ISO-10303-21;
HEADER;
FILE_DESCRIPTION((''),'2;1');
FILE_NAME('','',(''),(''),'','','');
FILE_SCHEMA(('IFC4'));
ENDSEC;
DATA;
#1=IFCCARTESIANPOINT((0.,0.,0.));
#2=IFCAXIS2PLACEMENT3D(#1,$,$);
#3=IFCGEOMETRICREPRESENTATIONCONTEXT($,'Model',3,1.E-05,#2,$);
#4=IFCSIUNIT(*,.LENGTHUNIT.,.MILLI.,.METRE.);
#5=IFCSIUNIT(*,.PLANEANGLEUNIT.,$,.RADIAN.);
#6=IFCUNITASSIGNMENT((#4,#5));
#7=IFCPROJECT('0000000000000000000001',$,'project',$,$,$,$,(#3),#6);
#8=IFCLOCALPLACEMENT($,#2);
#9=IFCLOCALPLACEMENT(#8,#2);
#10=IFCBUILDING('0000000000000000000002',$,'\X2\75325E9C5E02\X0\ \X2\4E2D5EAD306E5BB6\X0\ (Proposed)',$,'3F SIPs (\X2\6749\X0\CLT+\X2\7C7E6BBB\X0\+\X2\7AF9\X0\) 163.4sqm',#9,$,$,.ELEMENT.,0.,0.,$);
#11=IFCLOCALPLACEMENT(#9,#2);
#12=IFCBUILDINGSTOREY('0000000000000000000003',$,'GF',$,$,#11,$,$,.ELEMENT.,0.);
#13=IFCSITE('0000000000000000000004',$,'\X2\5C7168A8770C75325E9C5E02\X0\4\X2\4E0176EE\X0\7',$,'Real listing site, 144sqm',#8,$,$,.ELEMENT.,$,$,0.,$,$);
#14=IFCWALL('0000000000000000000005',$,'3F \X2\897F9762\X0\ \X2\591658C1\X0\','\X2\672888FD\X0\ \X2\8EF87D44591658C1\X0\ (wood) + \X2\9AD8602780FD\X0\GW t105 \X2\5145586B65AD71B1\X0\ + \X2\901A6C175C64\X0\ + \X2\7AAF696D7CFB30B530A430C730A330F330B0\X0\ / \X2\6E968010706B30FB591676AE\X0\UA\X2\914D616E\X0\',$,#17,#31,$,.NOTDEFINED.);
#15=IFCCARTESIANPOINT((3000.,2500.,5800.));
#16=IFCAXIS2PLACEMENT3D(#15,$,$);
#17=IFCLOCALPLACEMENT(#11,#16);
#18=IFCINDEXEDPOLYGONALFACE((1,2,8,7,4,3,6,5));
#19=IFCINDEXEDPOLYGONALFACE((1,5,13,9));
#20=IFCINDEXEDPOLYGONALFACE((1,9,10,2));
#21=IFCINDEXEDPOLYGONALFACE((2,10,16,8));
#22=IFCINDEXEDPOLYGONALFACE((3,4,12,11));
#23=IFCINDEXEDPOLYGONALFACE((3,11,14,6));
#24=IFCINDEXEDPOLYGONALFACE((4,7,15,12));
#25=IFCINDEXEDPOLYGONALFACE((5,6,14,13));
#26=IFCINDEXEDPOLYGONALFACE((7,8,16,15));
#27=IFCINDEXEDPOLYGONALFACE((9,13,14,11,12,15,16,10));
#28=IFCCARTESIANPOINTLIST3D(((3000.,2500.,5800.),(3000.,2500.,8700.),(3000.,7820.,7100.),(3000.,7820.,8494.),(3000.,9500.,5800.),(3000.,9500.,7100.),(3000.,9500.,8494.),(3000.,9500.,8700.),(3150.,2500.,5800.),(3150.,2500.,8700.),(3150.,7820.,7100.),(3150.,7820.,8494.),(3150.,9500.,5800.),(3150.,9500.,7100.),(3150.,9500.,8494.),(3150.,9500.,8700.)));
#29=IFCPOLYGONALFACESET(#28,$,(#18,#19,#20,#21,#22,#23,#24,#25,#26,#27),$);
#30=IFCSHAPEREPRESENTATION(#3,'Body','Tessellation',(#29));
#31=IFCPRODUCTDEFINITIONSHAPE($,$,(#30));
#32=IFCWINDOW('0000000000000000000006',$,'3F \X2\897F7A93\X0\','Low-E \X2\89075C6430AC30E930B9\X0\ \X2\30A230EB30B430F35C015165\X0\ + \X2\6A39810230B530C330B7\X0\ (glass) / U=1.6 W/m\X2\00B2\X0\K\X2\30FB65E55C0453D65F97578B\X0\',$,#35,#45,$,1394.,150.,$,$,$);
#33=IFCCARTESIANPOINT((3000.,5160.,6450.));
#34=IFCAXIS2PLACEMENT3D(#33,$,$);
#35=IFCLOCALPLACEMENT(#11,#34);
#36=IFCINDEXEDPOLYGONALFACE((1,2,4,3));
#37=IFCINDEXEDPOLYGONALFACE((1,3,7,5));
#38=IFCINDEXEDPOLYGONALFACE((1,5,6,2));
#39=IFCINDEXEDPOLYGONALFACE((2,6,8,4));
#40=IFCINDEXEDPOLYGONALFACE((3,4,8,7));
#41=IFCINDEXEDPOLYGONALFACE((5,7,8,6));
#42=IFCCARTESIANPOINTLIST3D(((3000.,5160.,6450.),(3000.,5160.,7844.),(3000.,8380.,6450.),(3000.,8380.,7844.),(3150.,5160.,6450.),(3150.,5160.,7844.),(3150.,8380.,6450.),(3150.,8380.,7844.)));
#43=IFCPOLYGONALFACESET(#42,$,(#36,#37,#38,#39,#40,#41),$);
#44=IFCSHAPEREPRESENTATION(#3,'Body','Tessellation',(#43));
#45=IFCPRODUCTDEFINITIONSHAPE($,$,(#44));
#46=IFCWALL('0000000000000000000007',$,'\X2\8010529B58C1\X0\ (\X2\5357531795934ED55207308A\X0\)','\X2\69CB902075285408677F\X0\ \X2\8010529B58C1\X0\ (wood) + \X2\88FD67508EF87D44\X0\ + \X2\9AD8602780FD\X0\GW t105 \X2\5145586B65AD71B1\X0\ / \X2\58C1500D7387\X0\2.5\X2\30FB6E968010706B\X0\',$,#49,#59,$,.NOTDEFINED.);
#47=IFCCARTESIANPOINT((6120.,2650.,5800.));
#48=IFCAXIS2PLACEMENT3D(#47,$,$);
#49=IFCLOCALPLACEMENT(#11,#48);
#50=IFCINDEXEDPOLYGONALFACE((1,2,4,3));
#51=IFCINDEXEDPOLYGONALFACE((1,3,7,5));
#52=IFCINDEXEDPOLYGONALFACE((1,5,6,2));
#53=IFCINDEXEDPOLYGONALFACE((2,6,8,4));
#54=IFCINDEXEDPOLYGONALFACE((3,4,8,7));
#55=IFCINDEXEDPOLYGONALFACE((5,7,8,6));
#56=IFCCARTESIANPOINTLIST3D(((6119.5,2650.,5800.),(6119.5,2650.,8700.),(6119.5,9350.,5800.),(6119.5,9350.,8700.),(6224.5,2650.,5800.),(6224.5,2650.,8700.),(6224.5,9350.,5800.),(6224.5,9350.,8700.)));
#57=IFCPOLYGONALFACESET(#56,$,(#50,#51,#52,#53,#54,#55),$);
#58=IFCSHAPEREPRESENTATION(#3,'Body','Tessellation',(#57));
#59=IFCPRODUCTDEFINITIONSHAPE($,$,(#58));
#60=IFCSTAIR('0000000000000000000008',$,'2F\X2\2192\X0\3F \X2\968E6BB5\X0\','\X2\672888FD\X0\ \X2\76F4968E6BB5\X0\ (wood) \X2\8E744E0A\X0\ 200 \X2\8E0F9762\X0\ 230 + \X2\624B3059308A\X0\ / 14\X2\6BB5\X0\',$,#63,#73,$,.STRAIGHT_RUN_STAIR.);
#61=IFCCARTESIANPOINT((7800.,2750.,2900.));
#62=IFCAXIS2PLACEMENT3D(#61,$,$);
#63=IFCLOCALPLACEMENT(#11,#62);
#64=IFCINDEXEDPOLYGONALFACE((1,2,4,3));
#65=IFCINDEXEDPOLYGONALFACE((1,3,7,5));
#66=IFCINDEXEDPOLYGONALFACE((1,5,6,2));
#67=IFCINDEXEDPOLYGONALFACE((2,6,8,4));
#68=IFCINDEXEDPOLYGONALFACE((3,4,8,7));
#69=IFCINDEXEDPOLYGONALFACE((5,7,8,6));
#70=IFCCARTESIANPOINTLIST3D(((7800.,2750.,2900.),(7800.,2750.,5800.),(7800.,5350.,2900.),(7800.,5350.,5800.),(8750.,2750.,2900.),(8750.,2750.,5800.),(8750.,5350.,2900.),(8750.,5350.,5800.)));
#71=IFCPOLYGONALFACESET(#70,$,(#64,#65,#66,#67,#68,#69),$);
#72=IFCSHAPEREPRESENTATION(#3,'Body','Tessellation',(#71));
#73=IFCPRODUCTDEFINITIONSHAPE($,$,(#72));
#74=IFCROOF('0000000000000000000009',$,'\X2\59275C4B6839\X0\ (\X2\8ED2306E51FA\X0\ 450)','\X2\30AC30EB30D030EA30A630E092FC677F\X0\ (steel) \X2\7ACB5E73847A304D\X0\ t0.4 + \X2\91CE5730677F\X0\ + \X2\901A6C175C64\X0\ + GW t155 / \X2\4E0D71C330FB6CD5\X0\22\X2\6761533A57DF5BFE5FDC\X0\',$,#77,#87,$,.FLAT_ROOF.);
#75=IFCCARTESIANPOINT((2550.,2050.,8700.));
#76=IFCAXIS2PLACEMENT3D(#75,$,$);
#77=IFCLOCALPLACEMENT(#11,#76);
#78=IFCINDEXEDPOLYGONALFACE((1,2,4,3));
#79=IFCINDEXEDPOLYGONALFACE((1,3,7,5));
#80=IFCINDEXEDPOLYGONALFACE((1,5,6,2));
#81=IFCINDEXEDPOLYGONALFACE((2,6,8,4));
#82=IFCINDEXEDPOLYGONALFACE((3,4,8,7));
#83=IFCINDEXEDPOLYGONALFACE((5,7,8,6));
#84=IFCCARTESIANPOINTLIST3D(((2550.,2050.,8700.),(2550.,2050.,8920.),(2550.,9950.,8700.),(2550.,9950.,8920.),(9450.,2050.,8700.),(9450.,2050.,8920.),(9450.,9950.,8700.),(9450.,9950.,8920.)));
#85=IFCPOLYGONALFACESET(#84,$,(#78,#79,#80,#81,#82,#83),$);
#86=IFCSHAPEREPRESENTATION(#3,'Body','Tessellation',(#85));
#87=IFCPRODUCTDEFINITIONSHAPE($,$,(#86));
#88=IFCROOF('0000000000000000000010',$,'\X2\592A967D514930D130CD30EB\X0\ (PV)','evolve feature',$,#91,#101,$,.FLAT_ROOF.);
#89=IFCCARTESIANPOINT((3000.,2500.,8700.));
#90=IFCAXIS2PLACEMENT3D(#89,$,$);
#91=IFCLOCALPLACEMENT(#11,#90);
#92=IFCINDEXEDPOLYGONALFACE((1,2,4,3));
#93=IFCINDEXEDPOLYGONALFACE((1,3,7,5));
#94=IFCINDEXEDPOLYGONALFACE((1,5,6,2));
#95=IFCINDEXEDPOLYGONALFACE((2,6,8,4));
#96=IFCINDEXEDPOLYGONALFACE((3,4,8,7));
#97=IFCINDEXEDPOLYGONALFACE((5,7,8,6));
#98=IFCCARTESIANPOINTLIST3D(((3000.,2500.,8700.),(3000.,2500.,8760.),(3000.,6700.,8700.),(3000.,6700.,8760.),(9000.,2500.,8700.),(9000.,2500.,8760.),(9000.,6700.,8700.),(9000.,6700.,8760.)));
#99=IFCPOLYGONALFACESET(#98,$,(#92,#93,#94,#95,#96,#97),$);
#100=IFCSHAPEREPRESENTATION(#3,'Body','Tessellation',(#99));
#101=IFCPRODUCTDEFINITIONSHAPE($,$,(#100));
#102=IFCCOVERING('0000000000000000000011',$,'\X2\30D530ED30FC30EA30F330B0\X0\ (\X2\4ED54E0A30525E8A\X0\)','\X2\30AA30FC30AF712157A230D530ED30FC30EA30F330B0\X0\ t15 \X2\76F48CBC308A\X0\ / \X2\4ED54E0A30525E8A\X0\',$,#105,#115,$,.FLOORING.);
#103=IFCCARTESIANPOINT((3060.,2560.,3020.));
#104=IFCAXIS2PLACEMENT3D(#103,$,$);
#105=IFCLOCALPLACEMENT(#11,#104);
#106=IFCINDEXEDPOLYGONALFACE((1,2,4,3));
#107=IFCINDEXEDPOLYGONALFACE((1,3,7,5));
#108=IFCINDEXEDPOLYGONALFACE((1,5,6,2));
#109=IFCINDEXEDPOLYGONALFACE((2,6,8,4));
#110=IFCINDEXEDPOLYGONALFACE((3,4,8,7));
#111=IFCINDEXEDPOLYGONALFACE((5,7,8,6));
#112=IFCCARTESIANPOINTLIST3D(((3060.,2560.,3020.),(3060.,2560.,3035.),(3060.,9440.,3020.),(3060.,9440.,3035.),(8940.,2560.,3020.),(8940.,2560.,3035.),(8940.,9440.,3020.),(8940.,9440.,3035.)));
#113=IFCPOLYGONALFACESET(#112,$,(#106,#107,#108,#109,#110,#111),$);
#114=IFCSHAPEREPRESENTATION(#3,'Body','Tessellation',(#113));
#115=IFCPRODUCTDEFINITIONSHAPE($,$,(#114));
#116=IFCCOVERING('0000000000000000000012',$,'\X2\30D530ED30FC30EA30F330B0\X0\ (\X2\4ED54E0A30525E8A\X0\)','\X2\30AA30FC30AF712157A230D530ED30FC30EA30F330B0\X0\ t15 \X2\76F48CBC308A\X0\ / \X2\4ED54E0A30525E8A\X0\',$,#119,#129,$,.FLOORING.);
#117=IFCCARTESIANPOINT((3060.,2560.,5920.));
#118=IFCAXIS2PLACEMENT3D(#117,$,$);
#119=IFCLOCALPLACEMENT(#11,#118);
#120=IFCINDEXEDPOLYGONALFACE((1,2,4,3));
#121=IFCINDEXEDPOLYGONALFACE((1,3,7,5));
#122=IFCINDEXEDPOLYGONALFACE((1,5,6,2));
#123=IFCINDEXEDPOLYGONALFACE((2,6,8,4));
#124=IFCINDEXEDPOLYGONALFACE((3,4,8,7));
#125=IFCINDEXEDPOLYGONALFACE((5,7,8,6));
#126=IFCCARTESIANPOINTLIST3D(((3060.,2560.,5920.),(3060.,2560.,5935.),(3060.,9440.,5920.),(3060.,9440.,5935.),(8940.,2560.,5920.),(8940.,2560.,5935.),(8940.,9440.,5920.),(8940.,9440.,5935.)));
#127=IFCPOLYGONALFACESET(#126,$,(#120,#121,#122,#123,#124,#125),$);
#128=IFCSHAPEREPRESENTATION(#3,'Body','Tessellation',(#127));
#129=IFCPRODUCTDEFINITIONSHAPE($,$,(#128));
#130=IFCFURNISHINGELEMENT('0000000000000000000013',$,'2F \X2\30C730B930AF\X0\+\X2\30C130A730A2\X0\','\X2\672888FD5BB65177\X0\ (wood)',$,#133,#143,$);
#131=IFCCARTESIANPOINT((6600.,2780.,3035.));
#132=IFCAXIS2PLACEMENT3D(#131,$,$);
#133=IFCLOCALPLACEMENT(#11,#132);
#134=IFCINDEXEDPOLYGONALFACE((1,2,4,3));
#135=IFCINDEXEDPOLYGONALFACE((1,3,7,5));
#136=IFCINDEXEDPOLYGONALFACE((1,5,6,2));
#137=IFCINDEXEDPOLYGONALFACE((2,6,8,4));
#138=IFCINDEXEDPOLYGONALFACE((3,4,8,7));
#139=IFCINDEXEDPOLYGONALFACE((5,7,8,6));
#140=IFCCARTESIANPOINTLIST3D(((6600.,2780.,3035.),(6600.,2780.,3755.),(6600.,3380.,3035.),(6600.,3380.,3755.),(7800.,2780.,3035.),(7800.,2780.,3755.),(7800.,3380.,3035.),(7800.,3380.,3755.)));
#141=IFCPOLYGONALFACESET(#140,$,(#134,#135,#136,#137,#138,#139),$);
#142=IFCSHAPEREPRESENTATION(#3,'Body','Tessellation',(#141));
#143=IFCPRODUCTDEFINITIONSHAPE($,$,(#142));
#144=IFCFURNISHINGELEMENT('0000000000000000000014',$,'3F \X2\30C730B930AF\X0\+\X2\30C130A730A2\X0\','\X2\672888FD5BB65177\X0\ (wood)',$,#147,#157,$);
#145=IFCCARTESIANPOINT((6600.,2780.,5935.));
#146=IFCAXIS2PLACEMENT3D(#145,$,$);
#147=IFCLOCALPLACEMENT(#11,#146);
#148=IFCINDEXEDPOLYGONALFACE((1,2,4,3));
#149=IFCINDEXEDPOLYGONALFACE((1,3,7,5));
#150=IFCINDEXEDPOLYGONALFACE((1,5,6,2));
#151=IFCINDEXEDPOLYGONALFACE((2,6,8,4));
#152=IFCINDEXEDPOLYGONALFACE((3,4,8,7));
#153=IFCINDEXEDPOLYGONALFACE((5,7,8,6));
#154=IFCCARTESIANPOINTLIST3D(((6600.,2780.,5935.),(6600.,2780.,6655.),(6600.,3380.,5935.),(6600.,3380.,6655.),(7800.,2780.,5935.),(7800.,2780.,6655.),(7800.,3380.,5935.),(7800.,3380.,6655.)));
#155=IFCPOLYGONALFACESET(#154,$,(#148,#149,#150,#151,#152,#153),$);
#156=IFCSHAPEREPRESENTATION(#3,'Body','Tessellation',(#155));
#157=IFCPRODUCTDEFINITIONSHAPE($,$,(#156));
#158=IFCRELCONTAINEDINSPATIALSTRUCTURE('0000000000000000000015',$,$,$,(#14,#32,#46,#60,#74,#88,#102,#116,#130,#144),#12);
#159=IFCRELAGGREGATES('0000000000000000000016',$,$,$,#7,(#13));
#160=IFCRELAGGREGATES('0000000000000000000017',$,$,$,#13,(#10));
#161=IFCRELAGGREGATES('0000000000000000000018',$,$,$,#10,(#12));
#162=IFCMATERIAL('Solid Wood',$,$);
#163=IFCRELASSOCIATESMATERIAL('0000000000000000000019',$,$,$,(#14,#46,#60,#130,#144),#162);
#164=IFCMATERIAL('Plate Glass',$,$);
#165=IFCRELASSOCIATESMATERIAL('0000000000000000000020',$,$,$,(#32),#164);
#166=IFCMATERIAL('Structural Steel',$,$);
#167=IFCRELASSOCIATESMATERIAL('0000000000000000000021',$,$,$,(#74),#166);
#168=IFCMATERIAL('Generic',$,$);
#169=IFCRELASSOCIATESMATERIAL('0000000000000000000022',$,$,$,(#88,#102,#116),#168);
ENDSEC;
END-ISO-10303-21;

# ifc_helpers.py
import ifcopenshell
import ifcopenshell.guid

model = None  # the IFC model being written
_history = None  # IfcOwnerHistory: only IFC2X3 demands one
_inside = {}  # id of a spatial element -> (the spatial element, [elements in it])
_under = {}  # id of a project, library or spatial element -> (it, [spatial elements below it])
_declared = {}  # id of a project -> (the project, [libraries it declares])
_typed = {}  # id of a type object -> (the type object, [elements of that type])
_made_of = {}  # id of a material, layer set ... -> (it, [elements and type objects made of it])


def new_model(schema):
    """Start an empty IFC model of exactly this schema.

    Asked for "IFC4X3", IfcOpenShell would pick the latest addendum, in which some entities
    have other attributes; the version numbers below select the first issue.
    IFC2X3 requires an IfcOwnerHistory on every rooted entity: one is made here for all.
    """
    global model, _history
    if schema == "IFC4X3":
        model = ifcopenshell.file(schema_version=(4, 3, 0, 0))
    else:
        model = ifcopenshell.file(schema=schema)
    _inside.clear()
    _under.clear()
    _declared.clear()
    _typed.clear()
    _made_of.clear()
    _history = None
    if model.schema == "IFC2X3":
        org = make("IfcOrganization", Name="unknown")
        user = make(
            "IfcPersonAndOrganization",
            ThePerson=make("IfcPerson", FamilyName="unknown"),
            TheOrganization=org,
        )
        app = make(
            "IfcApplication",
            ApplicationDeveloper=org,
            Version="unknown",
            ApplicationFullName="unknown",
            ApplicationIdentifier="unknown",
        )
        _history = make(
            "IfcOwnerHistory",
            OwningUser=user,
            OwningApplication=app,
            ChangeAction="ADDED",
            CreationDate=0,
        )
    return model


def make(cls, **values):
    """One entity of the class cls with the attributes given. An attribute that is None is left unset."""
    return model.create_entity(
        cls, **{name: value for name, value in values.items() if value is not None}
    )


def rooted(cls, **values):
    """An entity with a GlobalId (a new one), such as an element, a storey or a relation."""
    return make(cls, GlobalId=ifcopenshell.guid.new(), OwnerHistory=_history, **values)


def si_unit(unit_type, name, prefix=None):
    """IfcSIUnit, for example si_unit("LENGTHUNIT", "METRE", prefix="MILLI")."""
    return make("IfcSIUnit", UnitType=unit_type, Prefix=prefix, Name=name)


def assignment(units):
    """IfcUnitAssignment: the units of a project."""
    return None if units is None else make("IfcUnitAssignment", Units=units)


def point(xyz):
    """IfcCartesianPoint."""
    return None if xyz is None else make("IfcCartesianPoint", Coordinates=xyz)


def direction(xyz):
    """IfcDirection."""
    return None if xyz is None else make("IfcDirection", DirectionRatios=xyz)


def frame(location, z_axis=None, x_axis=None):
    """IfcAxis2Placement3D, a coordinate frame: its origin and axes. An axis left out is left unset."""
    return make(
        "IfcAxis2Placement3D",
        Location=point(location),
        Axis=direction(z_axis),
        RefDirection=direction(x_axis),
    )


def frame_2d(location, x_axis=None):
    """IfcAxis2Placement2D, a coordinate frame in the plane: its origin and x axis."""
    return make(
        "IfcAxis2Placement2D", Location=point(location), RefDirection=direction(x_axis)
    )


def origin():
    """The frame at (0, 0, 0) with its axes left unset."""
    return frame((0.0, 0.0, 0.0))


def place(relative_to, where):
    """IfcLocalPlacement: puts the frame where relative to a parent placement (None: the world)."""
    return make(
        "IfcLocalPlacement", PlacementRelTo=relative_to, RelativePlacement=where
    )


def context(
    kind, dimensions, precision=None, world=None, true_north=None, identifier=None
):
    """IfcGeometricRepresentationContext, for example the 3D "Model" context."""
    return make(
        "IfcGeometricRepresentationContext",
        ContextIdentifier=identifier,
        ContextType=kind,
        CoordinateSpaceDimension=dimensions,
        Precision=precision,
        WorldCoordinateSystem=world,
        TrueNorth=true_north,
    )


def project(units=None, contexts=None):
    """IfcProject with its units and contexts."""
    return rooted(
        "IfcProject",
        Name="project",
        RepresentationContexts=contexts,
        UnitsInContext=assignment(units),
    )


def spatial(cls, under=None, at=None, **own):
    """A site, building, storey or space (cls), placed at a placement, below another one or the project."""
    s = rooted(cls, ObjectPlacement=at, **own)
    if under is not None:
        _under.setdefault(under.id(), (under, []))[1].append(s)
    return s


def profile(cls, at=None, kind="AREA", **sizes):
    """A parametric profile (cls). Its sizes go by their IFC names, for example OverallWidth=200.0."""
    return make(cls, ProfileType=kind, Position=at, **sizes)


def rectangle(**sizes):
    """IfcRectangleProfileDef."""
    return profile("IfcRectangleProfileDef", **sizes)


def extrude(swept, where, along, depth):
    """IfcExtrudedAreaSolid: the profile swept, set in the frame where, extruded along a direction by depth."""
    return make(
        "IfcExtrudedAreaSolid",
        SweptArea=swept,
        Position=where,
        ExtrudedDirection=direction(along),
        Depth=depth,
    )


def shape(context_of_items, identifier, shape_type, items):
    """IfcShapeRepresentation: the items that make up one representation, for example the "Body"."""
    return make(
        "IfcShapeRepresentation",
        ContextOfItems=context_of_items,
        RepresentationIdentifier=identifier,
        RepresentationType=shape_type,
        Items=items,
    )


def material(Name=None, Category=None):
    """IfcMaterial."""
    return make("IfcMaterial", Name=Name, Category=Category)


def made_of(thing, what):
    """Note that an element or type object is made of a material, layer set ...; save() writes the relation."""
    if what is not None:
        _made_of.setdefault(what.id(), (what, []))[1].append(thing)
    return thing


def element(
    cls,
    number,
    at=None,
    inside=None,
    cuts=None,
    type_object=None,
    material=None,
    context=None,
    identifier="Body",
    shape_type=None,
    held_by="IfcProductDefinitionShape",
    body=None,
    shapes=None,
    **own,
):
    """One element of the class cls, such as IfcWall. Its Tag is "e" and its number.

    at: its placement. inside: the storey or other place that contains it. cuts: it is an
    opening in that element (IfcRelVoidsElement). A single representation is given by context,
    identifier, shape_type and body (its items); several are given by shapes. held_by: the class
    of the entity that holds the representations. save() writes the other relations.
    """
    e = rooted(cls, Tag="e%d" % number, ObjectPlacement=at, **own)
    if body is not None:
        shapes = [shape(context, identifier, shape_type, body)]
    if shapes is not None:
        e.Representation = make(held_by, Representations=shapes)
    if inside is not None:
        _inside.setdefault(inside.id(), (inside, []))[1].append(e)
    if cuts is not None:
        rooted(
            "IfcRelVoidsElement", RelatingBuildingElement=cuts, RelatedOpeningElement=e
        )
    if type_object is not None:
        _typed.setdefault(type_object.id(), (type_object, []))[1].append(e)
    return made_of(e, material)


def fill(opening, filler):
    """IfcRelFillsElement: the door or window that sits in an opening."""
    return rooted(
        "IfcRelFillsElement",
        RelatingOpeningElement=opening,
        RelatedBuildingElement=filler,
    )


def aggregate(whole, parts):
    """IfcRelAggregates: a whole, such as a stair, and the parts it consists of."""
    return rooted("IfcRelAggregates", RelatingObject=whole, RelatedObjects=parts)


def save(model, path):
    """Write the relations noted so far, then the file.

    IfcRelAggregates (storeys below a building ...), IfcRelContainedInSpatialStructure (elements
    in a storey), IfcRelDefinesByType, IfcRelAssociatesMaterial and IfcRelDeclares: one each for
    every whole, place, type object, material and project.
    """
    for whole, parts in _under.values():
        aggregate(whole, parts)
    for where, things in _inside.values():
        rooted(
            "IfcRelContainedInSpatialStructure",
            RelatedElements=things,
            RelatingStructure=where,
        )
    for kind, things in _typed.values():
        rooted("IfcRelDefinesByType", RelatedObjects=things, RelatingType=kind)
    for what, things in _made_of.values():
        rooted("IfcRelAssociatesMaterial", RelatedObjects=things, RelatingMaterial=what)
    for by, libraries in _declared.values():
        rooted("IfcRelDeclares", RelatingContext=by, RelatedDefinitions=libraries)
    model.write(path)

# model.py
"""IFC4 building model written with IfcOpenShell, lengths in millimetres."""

from ifc_helpers import new_model, si_unit, frame, frame_2d, origin, place, context, project, spatial, rectangle, extrude, material, element, fill, save


model = new_model("IFC4")

# Units and contexts
model_context = context("Model", 3, precision=1e-05, world=origin())
ifc_project = project(units=[si_unit("LENGTHUNIT", "METRE", prefix="MILLI"), si_unit("PLANEANGLEUNIT", "RADIAN")], contexts=[model_context])

# Site, building, storey
site_placement = place(None, origin())
site = spatial("IfcSite", under=ifc_project, at=site_placement, Name="山梨県甲府市4丁目7", ObjectType="Real listing site, 144sqm", CompositionType="ELEMENT", RefElevation=0.0)
building_placement = place(site_placement, origin())
building = spatial("IfcBuilding", under=site, at=building_placement, Name="甲府市 中庭の家 (Proposed)", ObjectType="3F SIPs (杉CLT+籾殻+竹) 163.4sqm", CompositionType="ELEMENT", ElevationOfRefHeight=0.0, ElevationOfTerrain=0.0)
storey_placement = place(building_placement, origin())
storey = spatial("IfcBuildingStorey", under=building, at=storey_placement, Name="GF", CompositionType="ELEMENT", Elevation=0.0)

# Shared definitions
ifc_material_1 = material(Name="Solid Wood")

# Shared definitions
ifc_material_2 = material(Name="Plate Glass")

# Shared definitions
ifc_material_3 = material(Name="Generic")

# Wall, opening, window
wall_1_placement = place(storey_placement, frame((3000.0, 2500.0, 5800.0)))
wall_1 = element("IfcWall", 1, at=wall_1_placement, inside=storey, material=ifc_material_1, Name="3F 西面 外壁", Description="木製 軸組外壁 (wood) + 高性能GW t105 充填断熱 + 通気層 + 窯業系サイディング / 準耐火・外皮UA配慮", PredefinedType="NOTDEFINED", context=model_context, shape_type="SweptSolid", body=[
    extrude(rectangle(XDim=150.0, YDim=7000.0, at=frame_2d((75.0, 3500.0))), frame((3000.0, 2500.0, 5800.0)), (0.0, 0.0, 1.0), 2900.0),
])
opening_1_placement = place(storey_placement, frame((3000.0, 5160.0, 6450.0)))
opening_1 = element("IfcOpeningElement", 2, at=opening_1_placement, cuts=wall_1, PredefinedType="NOTDEFINED", context=model_context, shape_type="SweptSolid", body=[
    extrude(rectangle(XDim=150.0, YDim=3220.0, at=frame_2d((75.0, 1610.0))), frame((3000.0, 5160.0, 6450.0)), (0.0, 0.0, 1.0), 1394.0),
])
window_1_placement = place(storey_placement, frame((3000.0, 5160.0, 6450.0)))
window_1 = element("IfcWindow", 3, at=window_1_placement, inside=storey, material=ifc_material_2, Name="3F 西窓", Description="Low-E 複層ガラス アルゴン封入 + 樹脂サッシ (glass) / U=1.6 W/m²K・日射取得型", OverallHeight=1394.0, OverallWidth=150.0, context=model_context, shape_type="SweptSolid", body=[
    extrude(rectangle(XDim=150.0, YDim=3220.0, at=frame_2d((75.0, 1610.0))), frame((3000.0, 5160.0, 6450.0)), (0.0, 0.0, 1.0), 1394.0),
])
fill(opening_1, window_1)

# Wall
wall_2_placement = place(storey_placement, frame((6120.0, 2650.0, 5800.0)))
element("IfcWall", 4, at=wall_2_placement, inside=storey, material=ifc_material_1, Name="耐力壁 (南北間仕切り)", Description="構造用合板 耐力壁 (wood) + 製材軸組 + 高性能GW t105 充填断熱 / 壁倍率2.5・準耐火", PredefinedType="NOTDEFINED", context=model_context, shape_type="SweptSolid", body=[
    extrude(rectangle(XDim=105.0, YDim=6700.0, at=frame_2d((52.0, 3350.0))), frame((6120.0, 2650.0, 5800.0)), (0.0, 0.0, 1.0), 2900.0),
])

# Stair
stair_placement = place(storey_placement, frame((7800.0, 2750.0, 2900.0)))
element("IfcStair", 5, at=stair_placement, inside=storey, material=ifc_material_1, Name="2F→3F 階段", Description="木製 直階段 (wood) 蹴上 200 踏面 230 + 手すり / 14段", PredefinedType="STRAIGHT_RUN_STAIR", context=model_context, shape_type="SweptSolid", body=[
    extrude(rectangle(XDim=950.0, YDim=2600.0, at=frame_2d((475.0, 1300.0))), frame((7800.0, 2750.0, 2900.0)), (0.0, 0.0, 1.0), 2900.0),
])

# Roofs
ifc_material_4 = material(Name="Structural Steel")
roof_1_placement = place(storey_placement, frame((2550.0, 2050.0, 8700.0)))
element("IfcRoof", 6, at=roof_1_placement, inside=storey, material=ifc_material_4, Name="大屋根 (軒の出 450)", Description="ガルバリウム鋼板 (steel) 立平葺き t0.4 + 野地板 + 通気層 + GW t155 / 不燃・法22条区域対応", PredefinedType="FLAT_ROOF", context=model_context, shape_type="SweptSolid", body=[
    extrude(rectangle(XDim=6900.0, YDim=7900.0, at=frame_2d((3450.0, 3950.0))), frame((2550.0, 2050.0, 8700.0)), (0.0, 0.0, 1.0), 220.0),
])
roof_2_placement = place(storey_placement, frame((3000.0, 2500.0, 8700.0)))
element("IfcRoof", 7, at=roof_2_placement, inside=storey, material=ifc_material_3, Name="太陽光パネル (PV)", Description="evolve feature", PredefinedType="FLAT_ROOF", context=model_context, shape_type="SweptSolid", body=[
    extrude(rectangle(XDim=6000.0, YDim=4200.0, at=frame_2d((3000.0, 2100.0))), frame((3000.0, 2500.0, 8700.0)), (0.0, 0.0, 1.0), 60.0),
])

# Coverings
covering_1_placement = place(storey_placement, frame((3060.0, 2560.0, 3020.0)))
element("IfcCovering", 8, at=covering_1_placement, inside=storey, material=ifc_material_3, Name="フローリング (仕上げ床)", Description="オーク無垢フローリング t15 直貼り / 仕上げ床", PredefinedType="FLOORING", context=model_context, shape_type="SweptSolid", body=[
    extrude(rectangle(XDim=5880.0, YDim=6880.0, at=frame_2d((2940.0, 3440.0))), frame((3060.0, 2560.0, 3020.0)), (0.0, 0.0, 1.0), 15.0),
])
covering_2_placement = place(storey_placement, frame((3060.0, 2560.0, 5920.0)))
element("IfcCovering", 9, at=covering_2_placement, inside=storey, material=ifc_material_3, Name="フローリング (仕上げ床)", Description="オーク無垢フローリング t15 直貼り / 仕上げ床", PredefinedType="FLOORING", context=model_context, shape_type="SweptSolid", body=[
    extrude(rectangle(XDim=5880.0, YDim=6880.0, at=frame_2d((2940.0, 3440.0))), frame((3060.0, 2560.0, 5920.0)), (0.0, 0.0, 1.0), 15.0),
])

# Furnishing elements
furnishing_1_placement = place(storey_placement, frame((6600.0, 2780.0, 3035.0)))
element("IfcFurnishingElement", 10, at=furnishing_1_placement, inside=storey, material=ifc_material_1, Name="2F デスク+チェア", Description="木製家具 (wood)", context=model_context, shape_type="SweptSolid", body=[
    extrude(rectangle(XDim=1200.0, YDim=600.0, at=frame_2d((600.0, 300.0))), frame((6600.0, 2780.0, 3035.0)), (0.0, 0.0, 1.0), 720.0),
])
furnishing_2_placement = place(storey_placement, frame((6600.0, 2780.0, 5935.0)))
element("IfcFurnishingElement", 11, at=furnishing_2_placement, inside=storey, material=ifc_material_1, Name="3F デスク+チェア", Description="木製家具 (wood)", context=model_context, shape_type="SweptSolid", body=[
    extrude(rectangle(XDim=1200.0, YDim=600.0, at=frame_2d((600.0, 300.0))), frame((6600.0, 2780.0, 5935.0)), (0.0, 0.0, 1.0), 720.0),
])

save(model, "model.ifc")
